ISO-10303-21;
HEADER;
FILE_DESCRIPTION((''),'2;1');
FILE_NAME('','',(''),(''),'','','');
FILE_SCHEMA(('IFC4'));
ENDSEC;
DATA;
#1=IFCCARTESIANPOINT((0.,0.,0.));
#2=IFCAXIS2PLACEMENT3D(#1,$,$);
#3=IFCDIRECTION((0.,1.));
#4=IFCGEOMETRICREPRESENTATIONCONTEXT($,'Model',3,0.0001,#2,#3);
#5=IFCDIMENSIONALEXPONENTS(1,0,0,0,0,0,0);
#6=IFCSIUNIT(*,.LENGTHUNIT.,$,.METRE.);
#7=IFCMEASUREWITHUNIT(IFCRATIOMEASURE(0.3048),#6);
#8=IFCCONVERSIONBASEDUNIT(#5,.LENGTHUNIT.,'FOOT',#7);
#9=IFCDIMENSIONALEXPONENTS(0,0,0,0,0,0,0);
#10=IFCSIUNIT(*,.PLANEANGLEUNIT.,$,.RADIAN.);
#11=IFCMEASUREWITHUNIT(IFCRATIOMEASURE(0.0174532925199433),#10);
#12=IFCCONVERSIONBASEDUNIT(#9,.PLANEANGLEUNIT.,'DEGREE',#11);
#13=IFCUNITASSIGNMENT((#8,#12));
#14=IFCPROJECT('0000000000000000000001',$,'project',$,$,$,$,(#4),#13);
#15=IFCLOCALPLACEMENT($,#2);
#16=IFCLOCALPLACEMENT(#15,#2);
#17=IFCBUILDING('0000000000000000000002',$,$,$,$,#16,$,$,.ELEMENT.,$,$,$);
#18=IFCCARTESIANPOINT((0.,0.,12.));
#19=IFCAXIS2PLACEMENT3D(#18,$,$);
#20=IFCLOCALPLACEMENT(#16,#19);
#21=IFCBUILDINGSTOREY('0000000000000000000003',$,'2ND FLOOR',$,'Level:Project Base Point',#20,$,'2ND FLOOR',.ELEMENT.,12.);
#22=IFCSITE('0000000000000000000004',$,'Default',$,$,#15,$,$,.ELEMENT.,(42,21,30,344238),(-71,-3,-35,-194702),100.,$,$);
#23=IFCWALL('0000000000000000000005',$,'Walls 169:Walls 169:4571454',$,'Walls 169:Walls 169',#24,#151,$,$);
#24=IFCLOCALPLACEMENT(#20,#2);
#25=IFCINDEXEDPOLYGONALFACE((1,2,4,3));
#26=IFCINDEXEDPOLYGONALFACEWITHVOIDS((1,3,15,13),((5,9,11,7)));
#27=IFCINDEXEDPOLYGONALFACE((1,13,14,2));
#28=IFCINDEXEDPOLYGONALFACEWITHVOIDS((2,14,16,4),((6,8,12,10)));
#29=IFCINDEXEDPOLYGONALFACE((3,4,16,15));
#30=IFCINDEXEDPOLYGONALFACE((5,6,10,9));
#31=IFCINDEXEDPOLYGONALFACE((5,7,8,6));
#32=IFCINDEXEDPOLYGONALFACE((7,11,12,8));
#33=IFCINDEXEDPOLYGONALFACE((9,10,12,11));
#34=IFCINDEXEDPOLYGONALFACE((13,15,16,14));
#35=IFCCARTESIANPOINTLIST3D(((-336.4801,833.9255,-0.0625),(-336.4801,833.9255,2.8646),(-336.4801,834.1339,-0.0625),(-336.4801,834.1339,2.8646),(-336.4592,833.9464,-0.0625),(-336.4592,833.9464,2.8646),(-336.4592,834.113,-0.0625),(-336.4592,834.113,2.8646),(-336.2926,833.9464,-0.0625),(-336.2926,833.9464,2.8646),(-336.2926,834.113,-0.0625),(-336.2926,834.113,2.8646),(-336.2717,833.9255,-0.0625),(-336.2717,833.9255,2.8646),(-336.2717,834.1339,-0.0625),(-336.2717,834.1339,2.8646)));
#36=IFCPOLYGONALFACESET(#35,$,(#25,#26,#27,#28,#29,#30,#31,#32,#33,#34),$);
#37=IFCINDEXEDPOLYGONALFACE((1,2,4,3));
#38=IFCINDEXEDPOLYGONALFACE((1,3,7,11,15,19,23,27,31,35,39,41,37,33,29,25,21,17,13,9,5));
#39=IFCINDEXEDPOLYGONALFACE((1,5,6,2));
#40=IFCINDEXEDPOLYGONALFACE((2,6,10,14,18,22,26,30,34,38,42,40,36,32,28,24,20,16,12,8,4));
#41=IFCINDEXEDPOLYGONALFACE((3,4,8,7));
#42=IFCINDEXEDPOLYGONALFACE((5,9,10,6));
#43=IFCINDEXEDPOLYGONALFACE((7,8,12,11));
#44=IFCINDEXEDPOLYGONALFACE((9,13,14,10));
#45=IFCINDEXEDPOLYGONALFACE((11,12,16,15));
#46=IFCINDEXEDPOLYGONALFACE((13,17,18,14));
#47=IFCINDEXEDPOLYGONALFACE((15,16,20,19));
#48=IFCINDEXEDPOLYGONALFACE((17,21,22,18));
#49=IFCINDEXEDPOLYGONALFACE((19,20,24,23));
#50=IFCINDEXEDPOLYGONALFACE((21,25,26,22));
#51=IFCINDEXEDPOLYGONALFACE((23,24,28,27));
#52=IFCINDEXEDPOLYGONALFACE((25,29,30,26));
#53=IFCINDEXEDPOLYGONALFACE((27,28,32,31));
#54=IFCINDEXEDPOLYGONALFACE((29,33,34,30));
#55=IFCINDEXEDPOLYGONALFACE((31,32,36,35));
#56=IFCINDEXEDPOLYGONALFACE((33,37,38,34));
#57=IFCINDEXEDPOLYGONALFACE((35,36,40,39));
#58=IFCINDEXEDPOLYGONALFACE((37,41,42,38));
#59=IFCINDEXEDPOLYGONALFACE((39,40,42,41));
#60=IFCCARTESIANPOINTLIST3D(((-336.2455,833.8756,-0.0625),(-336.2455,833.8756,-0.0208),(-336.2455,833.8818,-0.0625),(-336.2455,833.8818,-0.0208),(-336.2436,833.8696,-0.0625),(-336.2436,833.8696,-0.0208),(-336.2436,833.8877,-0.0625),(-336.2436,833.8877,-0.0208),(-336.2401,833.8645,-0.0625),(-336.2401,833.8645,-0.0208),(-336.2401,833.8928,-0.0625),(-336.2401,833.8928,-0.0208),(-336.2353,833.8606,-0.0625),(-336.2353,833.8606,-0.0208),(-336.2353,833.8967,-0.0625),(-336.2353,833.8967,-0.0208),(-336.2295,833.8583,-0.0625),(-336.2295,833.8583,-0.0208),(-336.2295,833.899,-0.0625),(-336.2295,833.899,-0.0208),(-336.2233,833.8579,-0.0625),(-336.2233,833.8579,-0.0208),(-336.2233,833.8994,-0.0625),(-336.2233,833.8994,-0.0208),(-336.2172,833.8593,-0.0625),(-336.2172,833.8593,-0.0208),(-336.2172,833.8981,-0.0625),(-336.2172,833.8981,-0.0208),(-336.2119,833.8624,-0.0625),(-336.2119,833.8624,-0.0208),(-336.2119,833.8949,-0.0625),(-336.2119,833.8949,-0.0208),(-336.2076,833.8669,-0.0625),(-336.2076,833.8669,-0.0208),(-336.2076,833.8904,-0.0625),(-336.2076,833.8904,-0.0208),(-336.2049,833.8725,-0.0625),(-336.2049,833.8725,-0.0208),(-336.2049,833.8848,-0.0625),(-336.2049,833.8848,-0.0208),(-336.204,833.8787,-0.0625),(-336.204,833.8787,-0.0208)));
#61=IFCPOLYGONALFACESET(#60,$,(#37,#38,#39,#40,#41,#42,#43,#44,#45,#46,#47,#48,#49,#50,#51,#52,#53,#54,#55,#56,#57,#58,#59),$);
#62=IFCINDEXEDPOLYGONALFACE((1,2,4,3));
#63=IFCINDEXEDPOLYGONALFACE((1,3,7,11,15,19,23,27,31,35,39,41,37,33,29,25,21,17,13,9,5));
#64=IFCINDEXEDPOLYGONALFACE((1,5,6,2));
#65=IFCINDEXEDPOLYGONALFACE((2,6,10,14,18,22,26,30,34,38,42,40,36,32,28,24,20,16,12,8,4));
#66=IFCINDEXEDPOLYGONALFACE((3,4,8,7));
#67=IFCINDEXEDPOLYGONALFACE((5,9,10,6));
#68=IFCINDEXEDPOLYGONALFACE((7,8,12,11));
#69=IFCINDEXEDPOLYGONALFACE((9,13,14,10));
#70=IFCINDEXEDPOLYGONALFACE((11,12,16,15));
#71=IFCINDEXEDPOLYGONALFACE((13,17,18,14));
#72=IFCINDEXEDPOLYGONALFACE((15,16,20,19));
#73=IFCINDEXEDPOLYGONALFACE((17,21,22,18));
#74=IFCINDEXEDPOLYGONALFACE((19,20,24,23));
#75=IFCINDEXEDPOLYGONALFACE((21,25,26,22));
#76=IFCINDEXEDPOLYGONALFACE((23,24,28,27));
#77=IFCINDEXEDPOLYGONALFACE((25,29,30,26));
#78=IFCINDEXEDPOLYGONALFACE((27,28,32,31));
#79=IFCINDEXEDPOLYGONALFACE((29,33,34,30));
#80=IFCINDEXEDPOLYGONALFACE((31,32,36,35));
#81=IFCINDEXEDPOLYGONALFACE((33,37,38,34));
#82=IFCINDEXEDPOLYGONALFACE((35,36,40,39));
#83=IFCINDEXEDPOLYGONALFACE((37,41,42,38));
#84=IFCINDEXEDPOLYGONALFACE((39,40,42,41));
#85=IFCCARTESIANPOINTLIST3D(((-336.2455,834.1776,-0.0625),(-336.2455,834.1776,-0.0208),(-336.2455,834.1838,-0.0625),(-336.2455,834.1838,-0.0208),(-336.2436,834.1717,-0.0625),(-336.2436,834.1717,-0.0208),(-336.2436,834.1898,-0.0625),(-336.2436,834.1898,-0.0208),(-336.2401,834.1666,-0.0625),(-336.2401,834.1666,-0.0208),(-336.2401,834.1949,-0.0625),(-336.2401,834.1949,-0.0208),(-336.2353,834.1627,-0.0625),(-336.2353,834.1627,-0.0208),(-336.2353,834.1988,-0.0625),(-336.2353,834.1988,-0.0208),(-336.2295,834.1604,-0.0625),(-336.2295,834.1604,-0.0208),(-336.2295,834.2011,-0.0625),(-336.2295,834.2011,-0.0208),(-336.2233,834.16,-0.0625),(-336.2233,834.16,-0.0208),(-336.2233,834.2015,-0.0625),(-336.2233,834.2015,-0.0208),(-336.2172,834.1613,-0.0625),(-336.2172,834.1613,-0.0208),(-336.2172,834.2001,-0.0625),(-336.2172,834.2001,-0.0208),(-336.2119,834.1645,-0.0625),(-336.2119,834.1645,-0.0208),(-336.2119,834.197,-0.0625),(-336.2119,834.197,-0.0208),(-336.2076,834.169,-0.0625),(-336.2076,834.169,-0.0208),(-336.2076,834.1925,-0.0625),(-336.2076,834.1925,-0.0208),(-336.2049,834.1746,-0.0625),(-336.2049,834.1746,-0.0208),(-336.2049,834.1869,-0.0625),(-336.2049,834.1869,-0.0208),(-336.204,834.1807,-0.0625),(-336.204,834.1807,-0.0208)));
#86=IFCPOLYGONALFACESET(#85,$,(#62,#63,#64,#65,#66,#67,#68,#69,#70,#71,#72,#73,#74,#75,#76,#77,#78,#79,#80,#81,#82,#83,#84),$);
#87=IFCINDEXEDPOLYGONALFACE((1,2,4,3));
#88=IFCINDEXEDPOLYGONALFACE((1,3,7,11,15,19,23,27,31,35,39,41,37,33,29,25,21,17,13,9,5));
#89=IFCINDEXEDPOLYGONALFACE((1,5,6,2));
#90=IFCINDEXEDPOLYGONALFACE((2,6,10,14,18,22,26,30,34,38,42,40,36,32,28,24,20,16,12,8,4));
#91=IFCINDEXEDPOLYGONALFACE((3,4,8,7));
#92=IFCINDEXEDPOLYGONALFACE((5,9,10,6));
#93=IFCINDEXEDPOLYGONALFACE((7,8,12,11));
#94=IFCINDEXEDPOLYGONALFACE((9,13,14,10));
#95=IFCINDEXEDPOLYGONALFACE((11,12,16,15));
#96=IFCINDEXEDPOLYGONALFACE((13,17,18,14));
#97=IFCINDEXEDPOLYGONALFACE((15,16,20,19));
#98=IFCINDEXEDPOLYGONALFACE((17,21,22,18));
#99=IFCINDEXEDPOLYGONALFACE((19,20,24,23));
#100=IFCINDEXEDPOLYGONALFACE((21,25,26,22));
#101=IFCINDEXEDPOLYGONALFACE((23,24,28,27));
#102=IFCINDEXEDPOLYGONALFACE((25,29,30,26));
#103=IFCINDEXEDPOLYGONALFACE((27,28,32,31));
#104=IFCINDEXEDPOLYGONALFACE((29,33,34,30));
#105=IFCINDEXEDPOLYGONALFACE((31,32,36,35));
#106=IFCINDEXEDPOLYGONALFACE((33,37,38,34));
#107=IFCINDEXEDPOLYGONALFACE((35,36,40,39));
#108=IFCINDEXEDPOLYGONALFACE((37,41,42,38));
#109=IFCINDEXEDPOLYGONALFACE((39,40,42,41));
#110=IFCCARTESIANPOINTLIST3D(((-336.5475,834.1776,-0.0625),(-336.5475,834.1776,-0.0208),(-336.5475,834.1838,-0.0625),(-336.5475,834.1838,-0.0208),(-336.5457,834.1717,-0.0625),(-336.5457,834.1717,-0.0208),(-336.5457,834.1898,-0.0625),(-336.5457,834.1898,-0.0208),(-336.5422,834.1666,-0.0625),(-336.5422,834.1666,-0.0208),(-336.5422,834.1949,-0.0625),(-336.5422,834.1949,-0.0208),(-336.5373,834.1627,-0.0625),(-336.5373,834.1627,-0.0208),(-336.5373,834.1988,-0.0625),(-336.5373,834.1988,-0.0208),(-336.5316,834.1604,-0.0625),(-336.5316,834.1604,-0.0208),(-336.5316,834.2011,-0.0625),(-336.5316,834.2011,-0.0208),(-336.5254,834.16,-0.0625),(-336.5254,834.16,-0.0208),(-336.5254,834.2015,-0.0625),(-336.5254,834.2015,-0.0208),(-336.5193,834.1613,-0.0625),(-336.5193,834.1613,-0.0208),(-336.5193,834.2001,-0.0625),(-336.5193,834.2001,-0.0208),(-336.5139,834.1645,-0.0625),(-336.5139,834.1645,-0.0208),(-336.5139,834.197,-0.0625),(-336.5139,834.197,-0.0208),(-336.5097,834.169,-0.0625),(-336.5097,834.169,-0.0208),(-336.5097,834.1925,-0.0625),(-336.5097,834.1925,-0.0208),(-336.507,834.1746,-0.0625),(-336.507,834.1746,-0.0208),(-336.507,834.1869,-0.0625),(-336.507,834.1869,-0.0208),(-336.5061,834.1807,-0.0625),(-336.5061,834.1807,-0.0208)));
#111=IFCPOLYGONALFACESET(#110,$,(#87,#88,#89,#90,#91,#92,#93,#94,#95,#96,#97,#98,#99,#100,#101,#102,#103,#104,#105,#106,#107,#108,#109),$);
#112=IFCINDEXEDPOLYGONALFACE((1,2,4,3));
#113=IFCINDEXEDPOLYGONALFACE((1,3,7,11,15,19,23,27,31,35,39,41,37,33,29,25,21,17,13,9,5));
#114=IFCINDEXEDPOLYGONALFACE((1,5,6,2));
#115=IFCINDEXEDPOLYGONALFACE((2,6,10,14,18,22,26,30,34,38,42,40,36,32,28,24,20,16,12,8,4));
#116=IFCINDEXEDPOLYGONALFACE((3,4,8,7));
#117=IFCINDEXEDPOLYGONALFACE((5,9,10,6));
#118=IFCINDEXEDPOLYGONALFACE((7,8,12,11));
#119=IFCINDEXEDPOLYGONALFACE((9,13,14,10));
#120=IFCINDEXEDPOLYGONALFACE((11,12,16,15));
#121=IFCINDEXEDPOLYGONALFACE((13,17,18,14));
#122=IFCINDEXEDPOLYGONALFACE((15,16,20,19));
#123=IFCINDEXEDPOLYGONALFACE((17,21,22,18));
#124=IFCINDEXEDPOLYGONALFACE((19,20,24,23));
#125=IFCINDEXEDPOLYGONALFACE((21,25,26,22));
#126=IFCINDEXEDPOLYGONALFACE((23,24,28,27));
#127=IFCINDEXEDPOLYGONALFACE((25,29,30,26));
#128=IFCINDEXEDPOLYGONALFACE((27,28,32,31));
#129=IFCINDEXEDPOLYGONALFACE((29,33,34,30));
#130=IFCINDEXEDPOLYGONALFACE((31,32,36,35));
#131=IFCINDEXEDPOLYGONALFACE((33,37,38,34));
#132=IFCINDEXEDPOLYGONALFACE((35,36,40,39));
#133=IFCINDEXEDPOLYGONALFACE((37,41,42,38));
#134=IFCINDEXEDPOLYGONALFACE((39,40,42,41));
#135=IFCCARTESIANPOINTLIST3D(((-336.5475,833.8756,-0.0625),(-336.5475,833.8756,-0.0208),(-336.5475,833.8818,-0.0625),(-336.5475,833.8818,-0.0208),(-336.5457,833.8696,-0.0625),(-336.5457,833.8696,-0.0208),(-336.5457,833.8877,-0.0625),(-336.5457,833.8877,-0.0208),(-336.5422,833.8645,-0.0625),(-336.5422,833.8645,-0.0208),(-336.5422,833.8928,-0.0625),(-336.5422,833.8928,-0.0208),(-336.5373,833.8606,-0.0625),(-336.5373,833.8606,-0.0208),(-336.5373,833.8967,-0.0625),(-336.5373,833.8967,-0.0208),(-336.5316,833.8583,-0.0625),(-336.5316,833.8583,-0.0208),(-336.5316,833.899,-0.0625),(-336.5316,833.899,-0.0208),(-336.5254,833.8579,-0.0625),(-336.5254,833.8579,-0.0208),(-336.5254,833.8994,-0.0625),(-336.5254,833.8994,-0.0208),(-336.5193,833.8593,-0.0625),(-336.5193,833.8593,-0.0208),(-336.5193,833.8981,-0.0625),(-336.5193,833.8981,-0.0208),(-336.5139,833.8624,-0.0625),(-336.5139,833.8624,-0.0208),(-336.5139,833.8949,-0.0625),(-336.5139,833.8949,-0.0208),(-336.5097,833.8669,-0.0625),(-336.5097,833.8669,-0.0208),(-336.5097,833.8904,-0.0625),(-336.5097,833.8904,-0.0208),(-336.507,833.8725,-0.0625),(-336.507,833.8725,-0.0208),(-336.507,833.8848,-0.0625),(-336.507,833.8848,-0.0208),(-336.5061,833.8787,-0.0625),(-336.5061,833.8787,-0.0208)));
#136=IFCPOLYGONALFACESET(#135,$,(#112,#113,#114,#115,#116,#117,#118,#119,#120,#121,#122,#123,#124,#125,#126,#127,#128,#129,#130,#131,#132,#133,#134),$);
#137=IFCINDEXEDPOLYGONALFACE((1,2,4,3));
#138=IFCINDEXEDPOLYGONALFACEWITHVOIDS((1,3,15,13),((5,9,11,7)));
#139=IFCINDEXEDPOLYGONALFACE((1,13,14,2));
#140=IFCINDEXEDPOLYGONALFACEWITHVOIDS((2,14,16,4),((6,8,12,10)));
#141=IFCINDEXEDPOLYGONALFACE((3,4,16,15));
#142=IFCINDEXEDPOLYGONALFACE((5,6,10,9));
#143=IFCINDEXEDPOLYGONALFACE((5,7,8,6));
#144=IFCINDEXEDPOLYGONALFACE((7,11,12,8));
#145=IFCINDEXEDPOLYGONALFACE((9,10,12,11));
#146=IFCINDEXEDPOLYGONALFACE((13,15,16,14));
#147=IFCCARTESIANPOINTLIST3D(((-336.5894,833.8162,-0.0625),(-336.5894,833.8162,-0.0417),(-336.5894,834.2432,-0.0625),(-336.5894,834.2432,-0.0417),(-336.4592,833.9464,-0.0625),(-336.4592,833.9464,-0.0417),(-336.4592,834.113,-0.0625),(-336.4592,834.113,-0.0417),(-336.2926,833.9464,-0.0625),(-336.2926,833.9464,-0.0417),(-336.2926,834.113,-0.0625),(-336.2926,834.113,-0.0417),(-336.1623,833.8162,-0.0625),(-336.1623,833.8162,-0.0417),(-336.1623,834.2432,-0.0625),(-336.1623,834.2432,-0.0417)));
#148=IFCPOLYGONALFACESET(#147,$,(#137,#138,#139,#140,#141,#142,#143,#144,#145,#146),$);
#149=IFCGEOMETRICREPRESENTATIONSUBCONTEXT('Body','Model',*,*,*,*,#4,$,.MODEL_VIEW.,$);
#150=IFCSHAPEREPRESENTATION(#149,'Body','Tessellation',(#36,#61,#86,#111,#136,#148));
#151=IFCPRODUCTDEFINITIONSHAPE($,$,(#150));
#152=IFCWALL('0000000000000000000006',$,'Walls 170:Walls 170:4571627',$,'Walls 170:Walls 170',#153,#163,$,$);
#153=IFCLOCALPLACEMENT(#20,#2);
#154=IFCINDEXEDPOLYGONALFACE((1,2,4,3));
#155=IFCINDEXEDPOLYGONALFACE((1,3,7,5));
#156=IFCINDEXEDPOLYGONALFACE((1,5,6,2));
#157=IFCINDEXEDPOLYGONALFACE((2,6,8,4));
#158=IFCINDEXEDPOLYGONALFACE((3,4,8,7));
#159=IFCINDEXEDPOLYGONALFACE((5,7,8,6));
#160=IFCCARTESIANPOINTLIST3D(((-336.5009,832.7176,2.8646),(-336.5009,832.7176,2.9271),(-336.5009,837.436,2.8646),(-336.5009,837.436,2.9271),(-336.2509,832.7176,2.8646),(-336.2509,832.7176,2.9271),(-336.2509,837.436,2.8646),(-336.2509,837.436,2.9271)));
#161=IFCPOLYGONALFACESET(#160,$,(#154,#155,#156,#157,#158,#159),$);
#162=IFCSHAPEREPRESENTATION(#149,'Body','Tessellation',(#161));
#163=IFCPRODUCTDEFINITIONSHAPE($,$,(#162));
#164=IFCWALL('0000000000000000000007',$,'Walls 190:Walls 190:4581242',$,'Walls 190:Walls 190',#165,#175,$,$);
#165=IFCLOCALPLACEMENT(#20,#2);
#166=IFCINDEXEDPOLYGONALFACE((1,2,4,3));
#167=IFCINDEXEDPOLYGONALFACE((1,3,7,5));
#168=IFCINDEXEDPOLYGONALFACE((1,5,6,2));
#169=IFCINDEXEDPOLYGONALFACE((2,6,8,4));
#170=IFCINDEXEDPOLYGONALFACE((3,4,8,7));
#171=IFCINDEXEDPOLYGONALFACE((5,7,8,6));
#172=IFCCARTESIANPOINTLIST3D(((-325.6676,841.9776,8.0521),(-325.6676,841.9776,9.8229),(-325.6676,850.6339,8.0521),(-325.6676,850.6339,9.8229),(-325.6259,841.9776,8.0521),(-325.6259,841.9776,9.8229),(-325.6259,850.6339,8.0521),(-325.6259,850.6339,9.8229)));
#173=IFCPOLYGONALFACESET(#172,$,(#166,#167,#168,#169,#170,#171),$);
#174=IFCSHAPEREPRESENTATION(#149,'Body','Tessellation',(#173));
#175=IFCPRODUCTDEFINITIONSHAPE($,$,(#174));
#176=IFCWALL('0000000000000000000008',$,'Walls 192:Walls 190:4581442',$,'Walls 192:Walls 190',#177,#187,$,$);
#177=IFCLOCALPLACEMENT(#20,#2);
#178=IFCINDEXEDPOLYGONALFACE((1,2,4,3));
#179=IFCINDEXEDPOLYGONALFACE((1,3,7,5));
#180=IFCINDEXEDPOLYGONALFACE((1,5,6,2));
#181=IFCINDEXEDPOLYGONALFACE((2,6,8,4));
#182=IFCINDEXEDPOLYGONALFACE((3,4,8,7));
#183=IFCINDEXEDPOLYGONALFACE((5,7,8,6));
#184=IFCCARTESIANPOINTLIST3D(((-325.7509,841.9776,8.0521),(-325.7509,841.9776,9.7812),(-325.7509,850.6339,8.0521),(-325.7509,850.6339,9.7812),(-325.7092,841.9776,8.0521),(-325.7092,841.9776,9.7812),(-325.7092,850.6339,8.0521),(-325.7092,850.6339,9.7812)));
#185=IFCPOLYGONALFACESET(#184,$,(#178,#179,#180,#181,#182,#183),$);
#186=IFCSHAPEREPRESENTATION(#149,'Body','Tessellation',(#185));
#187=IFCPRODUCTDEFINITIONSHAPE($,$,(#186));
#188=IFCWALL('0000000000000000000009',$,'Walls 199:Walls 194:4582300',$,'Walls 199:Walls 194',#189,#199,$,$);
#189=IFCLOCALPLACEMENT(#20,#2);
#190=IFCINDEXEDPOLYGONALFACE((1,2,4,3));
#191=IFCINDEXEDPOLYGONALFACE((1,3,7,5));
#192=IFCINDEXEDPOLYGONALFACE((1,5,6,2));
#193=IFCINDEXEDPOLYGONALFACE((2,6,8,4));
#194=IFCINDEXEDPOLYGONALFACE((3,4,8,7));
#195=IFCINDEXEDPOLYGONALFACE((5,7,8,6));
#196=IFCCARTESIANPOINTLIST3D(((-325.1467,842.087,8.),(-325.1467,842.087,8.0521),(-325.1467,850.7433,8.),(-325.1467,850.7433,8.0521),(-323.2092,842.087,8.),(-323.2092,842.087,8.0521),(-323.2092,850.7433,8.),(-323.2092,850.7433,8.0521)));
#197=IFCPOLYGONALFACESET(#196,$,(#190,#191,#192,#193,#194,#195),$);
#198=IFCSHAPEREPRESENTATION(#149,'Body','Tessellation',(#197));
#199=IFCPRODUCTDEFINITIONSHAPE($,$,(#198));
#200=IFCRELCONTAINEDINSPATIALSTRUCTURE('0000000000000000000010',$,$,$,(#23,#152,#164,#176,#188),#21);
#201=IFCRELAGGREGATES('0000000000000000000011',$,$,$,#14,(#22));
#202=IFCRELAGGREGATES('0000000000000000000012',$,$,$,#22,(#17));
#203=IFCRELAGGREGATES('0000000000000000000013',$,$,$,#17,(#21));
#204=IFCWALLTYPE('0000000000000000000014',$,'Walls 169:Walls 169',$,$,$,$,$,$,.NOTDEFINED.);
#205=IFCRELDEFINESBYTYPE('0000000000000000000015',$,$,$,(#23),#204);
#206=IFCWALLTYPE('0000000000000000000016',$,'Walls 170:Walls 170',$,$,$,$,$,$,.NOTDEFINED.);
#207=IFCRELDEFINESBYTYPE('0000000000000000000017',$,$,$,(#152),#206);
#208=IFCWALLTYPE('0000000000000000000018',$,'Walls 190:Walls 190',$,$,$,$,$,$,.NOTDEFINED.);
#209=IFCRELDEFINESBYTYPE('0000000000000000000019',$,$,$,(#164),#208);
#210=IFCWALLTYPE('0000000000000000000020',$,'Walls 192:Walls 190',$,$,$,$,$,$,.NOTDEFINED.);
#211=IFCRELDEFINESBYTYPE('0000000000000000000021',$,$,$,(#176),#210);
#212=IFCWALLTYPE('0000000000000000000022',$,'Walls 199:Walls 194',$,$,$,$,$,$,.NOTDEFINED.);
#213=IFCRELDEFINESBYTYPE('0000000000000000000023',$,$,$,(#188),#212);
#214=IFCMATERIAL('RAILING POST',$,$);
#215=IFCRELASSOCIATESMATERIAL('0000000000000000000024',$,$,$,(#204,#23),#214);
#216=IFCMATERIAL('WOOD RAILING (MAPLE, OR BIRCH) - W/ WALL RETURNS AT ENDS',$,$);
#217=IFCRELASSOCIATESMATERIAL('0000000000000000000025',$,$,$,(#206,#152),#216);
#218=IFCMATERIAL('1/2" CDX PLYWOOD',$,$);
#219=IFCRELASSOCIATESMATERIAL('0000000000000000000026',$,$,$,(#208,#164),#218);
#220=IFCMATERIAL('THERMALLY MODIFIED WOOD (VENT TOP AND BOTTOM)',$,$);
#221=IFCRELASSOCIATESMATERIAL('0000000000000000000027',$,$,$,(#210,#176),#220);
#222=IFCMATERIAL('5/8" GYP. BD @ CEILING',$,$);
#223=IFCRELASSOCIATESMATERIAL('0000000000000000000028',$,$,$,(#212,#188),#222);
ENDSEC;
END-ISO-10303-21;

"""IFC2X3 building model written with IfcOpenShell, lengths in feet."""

from ifc_helpers import new_model, entity, si_unit, converted_unit, direction, frame, frame_2d, origin, origin_2d_with_axis, place, context, subcontext, project, spatial, rectangle, circle, extrude, material, type_object, element, save


model = new_model("IFC2X3")

# Units and contexts
model_context = context("Model", 3, precision=0.0001, world=origin(), true_north=direction((0.0, 1.0)))
body_context = subcontext(model_context, "Body", "Model", "MODEL_VIEW")
ifc_project = project(units=[converted_unit("LENGTHUNIT", "FOOT", entity("IfcRatioMeasure", 0.3048), si_unit("LENGTHUNIT", "METRE"), dimensions=[1, 0, 0, 0, 0, 0, 0]), converted_unit("PLANEANGLEUNIT", "DEGREE", entity("IfcRatioMeasure", 0.0174532925199433), si_unit("PLANEANGLEUNIT", "RADIAN"), dimensions=[0, 0, 0, 0, 0, 0, 0])], contexts=[model_context])

# Site, building, storey
site_placement = place(None, origin())
site = spatial("IfcSite", under=ifc_project, at=site_placement, Name="Default", CompositionType="ELEMENT", RefLatitude=(42, 21, 30, 344238), RefLongitude=(-71, -3, -35, -194702), RefElevation=100.0)
building_placement = place(site_placement, origin())
building = spatial("IfcBuilding", under=site, at=building_placement, CompositionType="ELEMENT")
storey_placement = place(building_placement, frame((0.0, 0.0, 12.0)))
storey = spatial("IfcBuildingStorey", under=building, at=storey_placement, Name="2ND FLOOR", ObjectType="Level:Project Base Point", LongName="2ND FLOOR", CompositionType="ELEMENT", Elevation=12.0)

# Shared definitions
ifc_material_1 = material(Name="1/2\" CDX PLYWOOD")
ifc_material_2 = material(Name="THERMALLY MODIFIED WOOD (VENT TOP AND BOTTOM)")
ifc_material_3 = material(Name="5/8\" GYP. BD @ CEILING")

# Wall, opening
ifc_material_4 = material(Name="RAILING POST")
wall_type_1 = type_object("IfcWallType", Name="Walls 169:Walls 169", PredefinedType="NOTDEFINED", material=ifc_material_4)
wall_1_placement = place(storey_placement, frame((-336.5894, 833.8162, -0.0625)))
wall_1 = element("IfcWall", 1, at=wall_1_placement, inside=storey, type_object=wall_type_1, material=ifc_material_4, Name="Walls 169:Walls 169:4571454", ObjectType="Walls 169:Walls 169", context=body_context, shape_type="SweptSolid", body=[
    extrude(rectangle(XDim=0.2083, YDim=0.2083, at=origin_2d_with_axis()), frame((0.2135, 0.2135, 0.0), z_axis=(0.0, 0.0, 1.0), x_axis=(-1.0, 0.0, 0.0)), (0.0, 0.0, 1.0), 2.9271),
    extrude(circle(Radius=0.0208, at=origin_2d_with_axis()), frame((0.3646, 0.0625, 0.0)), (0.0, 0.0, 1.0), 0.0417),
    extrude(circle(Radius=0.0208, at=origin_2d_with_axis()), frame((0.3646, 0.3646, 0.0)), (0.0, 0.0, 1.0), 0.0417),
    extrude(circle(Radius=0.0208, at=origin_2d_with_axis()), frame((0.0625, 0.3646, 0.0)), (0.0, 0.0, 1.0), 0.0417),
    extrude(circle(Radius=0.0208, at=origin_2d_with_axis()), frame((0.0625, 0.0625, 0.0)), (0.0, 0.0, 1.0), 0.0417),
    extrude(rectangle(XDim=0.4271, YDim=0.4271, at=origin_2d_with_axis()), frame((0.2135, 0.2135, 0.0), z_axis=(0.0, 0.0, 1.0), x_axis=(-1.0, 0.0, 0.0)), (0.0, 0.0, 1.0), 0.0208),
])
opening_placement = place(storey_placement, frame((-336.5894, 833.8162, -0.0625)))
element("IfcOpeningElement", 2, at=opening_placement, cuts=wall_1, ObjectType="Opening", context=body_context, shape_type="SweptSolid", body=[
    extrude(rectangle(XDim=0.1667, YDim=0.1667, at=origin_2d_with_axis()), frame((0.2135, 0.2135, 0.0), z_axis=(0.0, 0.0, 1.0), x_axis=(0.0, -1.0, 0.0)), (0.0, 0.0, 1.0), 2.9271),
])

# Walls
ifc_material_5 = material(Name="WOOD RAILING (MAPLE, OR BIRCH) - W/ WALL RETURNS AT ENDS")
wall_type_2 = type_object("IfcWallType", Name="Walls 170:Walls 170", PredefinedType="NOTDEFINED", material=ifc_material_5)
wall_2_placement = place(storey_placement, frame((-336.5009, 832.7176, 2.8646), z_axis=(0.0, 0.0, 1.0), x_axis=(0.0, 1.0, 0.0)))
element("IfcWall", 3, at=wall_2_placement, inside=storey, type_object=wall_type_2, material=ifc_material_5, Name="Walls 170:Walls 170:4571627", ObjectType="Walls 170:Walls 170", context=body_context, shape_type="SweptSolid", body=[
    extrude(rectangle(XDim=4.7184, YDim=0.25, at=frame_2d((0.0, 0.0), x_axis=(1.0, 0.0))), frame((2.3592, -0.125, 0.0), z_axis=(0.0, 0.0, 1.0), x_axis=(-1.0, 0.0, 0.0)), (0.0, 0.0, 1.0), 0.0625),
])
wall_type_3 = type_object("IfcWallType", Name="Walls 190:Walls 190", PredefinedType="NOTDEFINED", material=ifc_material_1)
wall_3_placement = place(storey_placement, frame((-325.6676, 841.9776, 8.0521), z_axis=(0.0, 0.0, 1.0), x_axis=(0.0, 1.0, 0.0)))
element("IfcWall", 4, at=wall_3_placement, inside=storey, type_object=wall_type_3, material=ifc_material_1, Name="Walls 190:Walls 190:4581242", ObjectType="Walls 190:Walls 190", context=body_context, shape_type="SweptSolid", body=[
    extrude(rectangle(XDim=8.6563, YDim=0.0417, at=frame_2d((0.0, 0.0), x_axis=(1.0, 0.0))), frame((4.3281, -0.0208, 0.0), z_axis=(0.0, 0.0, 1.0), x_axis=(-1.0, 0.0, 0.0)), (0.0, 0.0, 1.0), 1.7708),
])
wall_type_4 = type_object("IfcWallType", Name="Walls 192:Walls 190", PredefinedType="NOTDEFINED", material=ifc_material_2)
wall_4_placement = place(storey_placement, frame((-325.7509, 841.9776, 8.0521), z_axis=(0.0, 0.0, 1.0), x_axis=(0.0, 1.0, 0.0)))
element("IfcWall", 5, at=wall_4_placement, inside=storey, type_object=wall_type_4, material=ifc_material_2, Name="Walls 192:Walls 190:4581442", ObjectType="Walls 192:Walls 190", context=body_context, shape_type="SweptSolid", body=[
    extrude(rectangle(XDim=8.6563, YDim=0.0417, at=frame_2d((0.0, 0.0), x_axis=(1.0, 0.0))), frame((4.3281, -0.0208, 0.0), z_axis=(0.0, 0.0, 1.0), x_axis=(-1.0, 0.0, 0.0)), (0.0, 0.0, 1.0), 1.7292),
])
wall_type_5 = type_object("IfcWallType", Name="Walls 199:Walls 194", PredefinedType="NOTDEFINED", material=ifc_material_3)
wall_5_placement = place(storey_placement, frame((-325.1467, 842.087, 8.0), z_axis=(0.0, 0.0, 1.0), x_axis=(0.0, 1.0, 0.0)))
element("IfcWall", 6, at=wall_5_placement, inside=storey, type_object=wall_type_5, material=ifc_material_3, Name="Walls 199:Walls 194:4582300", ObjectType="Walls 199:Walls 194", context=body_context, shape_type="SweptSolid", body=[
    extrude(rectangle(XDim=8.6563, YDim=1.9375, at=origin_2d_with_axis()), frame((4.3281, -0.9688, 0.0), z_axis=(0.0, 0.0, 1.0), x_axis=(-1.0, 0.0, 0.0)), (0.0, 0.0, 1.0), 0.0521),
])

save(model, "model.ifc")
